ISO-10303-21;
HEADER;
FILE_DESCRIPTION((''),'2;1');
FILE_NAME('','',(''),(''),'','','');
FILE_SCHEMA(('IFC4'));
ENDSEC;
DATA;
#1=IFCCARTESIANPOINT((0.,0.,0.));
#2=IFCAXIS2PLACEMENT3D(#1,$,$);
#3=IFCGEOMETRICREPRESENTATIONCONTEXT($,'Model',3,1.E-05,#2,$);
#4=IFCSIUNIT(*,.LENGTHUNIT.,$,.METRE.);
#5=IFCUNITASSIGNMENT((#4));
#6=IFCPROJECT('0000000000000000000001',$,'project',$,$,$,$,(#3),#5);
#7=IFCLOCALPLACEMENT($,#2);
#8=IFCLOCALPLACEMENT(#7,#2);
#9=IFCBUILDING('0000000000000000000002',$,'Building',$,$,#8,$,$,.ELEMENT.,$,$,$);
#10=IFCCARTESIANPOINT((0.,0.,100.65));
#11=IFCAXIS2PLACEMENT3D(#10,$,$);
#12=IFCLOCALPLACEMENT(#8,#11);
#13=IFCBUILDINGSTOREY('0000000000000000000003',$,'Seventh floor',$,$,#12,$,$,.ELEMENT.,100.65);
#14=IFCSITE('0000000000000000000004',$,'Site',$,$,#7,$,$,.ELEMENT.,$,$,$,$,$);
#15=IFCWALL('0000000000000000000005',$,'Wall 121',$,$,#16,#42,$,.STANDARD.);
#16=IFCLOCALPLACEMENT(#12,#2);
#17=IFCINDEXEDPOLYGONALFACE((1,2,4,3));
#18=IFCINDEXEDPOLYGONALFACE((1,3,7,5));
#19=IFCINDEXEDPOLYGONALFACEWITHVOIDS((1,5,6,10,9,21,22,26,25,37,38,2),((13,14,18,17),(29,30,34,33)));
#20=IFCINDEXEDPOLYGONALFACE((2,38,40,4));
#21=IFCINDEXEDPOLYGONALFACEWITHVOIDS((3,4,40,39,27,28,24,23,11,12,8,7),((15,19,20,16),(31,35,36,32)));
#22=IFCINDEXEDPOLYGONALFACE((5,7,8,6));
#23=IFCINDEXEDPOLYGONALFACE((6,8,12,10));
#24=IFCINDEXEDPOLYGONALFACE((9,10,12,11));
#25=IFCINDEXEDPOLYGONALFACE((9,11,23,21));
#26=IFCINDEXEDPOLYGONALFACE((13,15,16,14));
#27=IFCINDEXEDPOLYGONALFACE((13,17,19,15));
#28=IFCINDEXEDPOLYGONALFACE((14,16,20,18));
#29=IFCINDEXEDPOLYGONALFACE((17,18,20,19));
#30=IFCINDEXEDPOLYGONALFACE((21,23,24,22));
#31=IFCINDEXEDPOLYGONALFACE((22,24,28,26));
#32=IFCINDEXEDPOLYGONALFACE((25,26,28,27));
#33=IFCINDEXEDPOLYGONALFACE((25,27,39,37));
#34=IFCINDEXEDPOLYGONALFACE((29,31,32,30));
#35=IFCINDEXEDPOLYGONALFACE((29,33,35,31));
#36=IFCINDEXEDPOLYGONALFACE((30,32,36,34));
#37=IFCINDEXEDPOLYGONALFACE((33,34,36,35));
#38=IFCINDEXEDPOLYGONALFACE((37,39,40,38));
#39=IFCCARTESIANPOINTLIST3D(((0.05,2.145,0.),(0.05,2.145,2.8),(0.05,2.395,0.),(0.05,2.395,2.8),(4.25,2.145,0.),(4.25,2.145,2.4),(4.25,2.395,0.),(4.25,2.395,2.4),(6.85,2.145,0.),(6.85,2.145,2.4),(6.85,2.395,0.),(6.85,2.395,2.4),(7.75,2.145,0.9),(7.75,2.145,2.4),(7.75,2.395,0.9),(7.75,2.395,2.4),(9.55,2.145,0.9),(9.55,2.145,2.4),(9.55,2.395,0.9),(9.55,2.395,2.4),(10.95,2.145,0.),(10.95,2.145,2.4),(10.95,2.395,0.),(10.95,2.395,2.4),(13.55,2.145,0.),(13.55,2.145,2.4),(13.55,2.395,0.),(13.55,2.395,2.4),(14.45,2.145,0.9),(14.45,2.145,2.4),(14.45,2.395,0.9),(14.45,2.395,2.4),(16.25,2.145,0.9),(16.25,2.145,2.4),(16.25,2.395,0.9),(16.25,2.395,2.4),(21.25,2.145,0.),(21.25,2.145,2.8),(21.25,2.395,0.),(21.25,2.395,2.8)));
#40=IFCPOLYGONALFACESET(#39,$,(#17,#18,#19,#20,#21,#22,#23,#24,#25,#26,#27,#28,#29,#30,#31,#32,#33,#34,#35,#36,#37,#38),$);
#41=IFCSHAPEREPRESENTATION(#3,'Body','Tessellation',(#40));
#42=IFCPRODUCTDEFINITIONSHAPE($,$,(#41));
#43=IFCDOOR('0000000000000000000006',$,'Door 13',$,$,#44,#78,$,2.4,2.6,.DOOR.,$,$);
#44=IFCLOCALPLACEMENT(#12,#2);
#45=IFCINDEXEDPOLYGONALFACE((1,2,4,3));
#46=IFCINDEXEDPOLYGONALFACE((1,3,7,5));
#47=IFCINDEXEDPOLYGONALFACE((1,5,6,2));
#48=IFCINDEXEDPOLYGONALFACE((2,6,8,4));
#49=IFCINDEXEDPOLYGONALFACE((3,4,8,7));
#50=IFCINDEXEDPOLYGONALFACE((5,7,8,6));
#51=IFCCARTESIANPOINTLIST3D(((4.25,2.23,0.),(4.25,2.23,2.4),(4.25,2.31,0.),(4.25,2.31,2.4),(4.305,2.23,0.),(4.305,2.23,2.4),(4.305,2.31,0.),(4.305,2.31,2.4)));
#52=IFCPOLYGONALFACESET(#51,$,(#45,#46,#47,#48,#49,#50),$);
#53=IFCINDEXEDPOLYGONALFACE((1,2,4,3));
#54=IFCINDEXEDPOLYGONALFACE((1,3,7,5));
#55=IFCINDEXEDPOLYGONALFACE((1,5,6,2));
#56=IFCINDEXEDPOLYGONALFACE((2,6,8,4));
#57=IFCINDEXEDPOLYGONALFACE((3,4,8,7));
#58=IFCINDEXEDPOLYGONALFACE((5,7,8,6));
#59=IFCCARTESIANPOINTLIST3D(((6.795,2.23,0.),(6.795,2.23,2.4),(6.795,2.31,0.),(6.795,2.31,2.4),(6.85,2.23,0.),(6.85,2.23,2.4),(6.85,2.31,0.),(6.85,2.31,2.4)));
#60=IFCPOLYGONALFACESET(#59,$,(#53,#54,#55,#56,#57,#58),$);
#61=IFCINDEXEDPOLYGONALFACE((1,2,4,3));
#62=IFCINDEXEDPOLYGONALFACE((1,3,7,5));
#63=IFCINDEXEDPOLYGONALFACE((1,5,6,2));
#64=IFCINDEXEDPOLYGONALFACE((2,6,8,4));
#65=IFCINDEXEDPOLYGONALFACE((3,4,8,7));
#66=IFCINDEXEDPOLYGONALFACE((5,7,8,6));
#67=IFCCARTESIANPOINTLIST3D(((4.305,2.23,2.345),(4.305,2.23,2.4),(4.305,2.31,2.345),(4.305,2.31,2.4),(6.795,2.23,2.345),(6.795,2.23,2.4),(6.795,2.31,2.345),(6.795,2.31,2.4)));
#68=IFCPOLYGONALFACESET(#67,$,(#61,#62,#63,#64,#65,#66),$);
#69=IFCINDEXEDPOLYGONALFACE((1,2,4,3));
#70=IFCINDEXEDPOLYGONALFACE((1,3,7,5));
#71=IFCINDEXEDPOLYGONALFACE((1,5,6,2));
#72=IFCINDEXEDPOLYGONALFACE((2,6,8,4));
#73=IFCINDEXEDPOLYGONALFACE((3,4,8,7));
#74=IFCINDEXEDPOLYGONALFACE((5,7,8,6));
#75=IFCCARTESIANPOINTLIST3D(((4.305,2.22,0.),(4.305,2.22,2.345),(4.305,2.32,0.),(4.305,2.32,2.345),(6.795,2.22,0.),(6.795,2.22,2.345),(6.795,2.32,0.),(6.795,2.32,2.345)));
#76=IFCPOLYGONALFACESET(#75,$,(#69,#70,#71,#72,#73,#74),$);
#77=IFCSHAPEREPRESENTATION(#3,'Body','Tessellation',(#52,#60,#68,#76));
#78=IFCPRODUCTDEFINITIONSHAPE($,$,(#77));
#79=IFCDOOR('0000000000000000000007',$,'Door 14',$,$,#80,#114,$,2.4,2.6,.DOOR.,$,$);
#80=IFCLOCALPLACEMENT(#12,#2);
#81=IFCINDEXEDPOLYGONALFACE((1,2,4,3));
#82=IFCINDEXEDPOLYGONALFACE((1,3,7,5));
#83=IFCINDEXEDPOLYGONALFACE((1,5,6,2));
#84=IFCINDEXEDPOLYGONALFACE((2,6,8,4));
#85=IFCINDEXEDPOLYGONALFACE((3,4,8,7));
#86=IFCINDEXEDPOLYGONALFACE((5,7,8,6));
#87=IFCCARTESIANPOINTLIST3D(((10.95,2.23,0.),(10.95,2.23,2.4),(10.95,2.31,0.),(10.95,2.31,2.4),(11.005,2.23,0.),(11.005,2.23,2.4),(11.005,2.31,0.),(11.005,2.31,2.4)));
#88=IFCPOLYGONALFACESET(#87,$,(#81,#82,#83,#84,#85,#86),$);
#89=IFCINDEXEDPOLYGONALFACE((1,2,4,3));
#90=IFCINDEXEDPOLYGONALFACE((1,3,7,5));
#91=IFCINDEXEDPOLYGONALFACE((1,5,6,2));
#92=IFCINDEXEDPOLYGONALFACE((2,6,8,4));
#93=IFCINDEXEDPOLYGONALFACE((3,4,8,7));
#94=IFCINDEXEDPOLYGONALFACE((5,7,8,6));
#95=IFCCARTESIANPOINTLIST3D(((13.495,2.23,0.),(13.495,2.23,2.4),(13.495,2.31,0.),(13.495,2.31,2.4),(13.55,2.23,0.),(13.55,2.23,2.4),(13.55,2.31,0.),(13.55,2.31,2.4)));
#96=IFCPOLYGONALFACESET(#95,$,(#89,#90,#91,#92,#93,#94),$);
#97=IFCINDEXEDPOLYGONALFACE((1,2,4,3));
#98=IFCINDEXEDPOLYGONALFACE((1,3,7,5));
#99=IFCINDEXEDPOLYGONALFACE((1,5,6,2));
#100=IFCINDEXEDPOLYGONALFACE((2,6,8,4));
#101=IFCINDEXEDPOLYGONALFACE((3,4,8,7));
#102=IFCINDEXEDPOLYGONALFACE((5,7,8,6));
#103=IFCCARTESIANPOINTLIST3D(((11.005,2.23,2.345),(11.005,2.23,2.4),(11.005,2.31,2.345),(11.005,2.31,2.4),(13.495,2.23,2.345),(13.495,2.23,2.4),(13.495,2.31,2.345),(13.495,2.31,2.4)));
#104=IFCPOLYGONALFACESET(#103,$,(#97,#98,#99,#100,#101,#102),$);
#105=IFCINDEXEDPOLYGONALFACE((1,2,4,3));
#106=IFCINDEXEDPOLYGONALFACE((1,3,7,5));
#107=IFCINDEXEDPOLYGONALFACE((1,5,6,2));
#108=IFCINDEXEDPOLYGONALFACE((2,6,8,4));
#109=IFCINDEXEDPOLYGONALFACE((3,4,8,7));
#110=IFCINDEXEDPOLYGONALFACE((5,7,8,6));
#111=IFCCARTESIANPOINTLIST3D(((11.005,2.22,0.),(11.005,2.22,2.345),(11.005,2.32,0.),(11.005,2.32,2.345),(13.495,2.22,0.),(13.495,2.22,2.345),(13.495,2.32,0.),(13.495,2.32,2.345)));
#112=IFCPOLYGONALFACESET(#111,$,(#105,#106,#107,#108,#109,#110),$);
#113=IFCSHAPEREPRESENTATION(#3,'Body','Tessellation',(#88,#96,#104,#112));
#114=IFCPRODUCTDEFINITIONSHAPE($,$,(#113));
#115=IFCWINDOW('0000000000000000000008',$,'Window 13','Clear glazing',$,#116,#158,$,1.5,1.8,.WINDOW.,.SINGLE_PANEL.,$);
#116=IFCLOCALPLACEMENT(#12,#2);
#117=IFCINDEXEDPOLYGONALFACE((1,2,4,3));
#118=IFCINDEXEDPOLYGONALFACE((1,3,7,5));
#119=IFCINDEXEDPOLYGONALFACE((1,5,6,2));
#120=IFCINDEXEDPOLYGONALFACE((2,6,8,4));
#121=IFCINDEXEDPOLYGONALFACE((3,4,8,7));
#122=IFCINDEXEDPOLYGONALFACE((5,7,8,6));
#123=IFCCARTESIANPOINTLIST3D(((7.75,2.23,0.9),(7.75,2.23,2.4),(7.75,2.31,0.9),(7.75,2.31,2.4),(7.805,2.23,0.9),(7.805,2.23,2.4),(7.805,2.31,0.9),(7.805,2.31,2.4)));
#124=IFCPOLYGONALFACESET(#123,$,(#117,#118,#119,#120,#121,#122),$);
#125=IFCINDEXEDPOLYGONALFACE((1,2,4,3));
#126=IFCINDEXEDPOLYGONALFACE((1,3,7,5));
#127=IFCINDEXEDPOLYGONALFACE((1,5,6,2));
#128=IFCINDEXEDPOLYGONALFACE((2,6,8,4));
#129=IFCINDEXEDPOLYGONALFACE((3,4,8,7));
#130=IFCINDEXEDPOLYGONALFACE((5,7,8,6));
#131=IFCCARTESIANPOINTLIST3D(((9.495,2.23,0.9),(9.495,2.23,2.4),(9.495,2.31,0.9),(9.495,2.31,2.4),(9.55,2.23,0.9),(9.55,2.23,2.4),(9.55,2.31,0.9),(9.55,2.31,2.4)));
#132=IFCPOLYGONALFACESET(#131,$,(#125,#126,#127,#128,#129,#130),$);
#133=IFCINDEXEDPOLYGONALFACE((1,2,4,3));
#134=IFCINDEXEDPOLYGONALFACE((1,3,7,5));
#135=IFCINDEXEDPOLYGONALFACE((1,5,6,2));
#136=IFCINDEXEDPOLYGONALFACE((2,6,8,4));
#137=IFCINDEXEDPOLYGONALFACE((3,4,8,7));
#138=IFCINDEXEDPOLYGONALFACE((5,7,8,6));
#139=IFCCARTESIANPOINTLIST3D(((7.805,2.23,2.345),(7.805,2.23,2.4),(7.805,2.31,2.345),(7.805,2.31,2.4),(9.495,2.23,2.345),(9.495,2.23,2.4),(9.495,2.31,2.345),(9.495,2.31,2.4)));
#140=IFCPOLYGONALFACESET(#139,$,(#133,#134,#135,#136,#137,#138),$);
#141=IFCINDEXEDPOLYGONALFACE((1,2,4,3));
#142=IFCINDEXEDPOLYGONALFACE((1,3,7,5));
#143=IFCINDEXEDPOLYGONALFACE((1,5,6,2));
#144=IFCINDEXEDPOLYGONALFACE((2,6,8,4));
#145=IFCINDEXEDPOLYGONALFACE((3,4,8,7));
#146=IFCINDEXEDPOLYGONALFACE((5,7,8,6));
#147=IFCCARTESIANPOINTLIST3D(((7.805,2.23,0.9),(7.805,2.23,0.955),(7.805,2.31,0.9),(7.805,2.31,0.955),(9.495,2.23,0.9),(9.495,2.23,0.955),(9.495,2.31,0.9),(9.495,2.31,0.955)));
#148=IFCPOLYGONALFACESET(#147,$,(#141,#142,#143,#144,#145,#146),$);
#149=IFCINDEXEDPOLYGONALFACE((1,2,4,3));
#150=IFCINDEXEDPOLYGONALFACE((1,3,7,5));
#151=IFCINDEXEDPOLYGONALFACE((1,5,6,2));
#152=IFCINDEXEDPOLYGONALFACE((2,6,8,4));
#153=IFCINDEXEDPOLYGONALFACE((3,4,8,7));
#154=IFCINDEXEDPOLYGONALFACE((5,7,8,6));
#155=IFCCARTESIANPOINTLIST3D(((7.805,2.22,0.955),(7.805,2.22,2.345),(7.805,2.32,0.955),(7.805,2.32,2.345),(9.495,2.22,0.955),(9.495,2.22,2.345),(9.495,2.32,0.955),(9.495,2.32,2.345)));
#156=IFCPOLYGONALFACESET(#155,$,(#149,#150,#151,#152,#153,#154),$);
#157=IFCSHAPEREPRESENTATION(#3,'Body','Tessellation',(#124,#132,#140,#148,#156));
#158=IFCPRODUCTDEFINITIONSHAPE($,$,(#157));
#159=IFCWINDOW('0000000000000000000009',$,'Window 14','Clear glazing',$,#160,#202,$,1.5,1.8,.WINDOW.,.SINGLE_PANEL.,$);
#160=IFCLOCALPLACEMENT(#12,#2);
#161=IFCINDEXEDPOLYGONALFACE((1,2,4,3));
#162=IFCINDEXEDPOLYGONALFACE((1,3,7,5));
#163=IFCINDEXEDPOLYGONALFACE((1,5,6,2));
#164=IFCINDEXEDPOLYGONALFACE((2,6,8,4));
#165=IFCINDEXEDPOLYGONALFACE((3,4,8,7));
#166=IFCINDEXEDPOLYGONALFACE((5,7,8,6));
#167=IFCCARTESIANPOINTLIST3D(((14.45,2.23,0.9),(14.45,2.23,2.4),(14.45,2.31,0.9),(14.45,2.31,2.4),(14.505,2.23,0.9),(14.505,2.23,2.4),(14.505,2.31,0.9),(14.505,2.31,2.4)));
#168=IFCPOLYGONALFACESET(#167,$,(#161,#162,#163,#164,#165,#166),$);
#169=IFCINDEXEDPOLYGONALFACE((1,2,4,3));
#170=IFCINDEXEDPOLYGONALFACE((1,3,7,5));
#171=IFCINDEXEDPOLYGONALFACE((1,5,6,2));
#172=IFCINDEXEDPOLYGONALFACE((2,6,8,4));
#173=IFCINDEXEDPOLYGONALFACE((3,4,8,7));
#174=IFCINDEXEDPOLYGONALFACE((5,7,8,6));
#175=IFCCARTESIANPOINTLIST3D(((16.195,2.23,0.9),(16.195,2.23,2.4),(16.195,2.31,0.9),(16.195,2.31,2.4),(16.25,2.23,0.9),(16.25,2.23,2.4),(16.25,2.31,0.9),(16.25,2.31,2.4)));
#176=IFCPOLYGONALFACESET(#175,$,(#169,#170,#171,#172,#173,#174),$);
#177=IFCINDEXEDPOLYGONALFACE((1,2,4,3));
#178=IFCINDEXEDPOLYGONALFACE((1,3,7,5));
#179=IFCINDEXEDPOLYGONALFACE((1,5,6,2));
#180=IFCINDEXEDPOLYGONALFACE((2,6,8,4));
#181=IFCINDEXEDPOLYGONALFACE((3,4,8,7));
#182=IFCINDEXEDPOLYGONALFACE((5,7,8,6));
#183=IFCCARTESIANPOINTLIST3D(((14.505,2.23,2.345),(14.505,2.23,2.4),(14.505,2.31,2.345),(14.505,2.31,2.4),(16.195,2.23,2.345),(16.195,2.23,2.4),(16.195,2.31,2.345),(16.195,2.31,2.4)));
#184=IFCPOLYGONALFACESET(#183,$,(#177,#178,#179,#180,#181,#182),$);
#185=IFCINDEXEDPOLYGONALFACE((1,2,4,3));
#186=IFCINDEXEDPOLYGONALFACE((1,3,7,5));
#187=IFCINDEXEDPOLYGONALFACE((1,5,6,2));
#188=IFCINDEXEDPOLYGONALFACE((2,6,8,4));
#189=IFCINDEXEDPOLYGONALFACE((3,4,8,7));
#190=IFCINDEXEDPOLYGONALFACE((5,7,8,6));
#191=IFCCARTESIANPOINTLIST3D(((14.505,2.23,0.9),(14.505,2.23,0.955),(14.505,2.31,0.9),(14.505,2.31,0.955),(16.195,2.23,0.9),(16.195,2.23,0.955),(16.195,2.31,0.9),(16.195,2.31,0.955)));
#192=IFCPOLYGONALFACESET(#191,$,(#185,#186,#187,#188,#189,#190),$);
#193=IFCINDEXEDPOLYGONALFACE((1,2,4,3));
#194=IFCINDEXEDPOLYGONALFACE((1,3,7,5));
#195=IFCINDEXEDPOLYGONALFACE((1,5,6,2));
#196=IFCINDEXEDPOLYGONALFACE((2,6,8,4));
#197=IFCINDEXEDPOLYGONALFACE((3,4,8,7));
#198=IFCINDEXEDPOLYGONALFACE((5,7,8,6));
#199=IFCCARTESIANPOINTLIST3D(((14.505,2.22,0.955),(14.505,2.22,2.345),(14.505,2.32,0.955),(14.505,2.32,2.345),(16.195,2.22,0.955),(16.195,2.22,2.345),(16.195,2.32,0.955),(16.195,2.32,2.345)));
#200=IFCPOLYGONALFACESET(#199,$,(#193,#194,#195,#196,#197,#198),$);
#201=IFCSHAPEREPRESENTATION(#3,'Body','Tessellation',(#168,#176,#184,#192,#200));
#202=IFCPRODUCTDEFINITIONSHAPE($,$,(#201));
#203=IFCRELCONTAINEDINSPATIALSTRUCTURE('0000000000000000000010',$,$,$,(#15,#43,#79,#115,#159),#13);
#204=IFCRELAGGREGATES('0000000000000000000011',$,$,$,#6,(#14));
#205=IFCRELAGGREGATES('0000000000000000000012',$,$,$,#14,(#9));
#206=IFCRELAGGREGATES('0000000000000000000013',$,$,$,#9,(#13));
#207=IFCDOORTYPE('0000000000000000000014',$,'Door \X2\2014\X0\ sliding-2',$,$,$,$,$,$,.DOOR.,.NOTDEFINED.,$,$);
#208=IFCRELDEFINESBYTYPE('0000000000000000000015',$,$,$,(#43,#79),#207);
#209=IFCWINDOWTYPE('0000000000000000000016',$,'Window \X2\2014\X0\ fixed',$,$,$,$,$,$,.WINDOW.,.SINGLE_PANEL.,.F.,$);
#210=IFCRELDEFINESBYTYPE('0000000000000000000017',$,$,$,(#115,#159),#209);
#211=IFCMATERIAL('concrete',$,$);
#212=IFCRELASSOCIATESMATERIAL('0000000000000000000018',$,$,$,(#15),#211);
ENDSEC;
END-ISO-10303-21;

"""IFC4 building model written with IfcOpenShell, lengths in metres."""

from ifc_helpers import new_model, si_unit, frame, frame_2d, origin, place, context, project, spatial, rectangle, extrude, material, type_object, element, fill, save


model = new_model("IFC4")

# Units and contexts
model_context = context("Model", 3, precision=1e-05, world=origin())
ifc_project = project(units=[si_unit("LENGTHUNIT", "METRE")], contexts=[model_context])

# Site, building, storey
site_placement = place(None, origin())
site = spatial("IfcSite", under=ifc_project, at=site_placement, Name="Site", CompositionType="ELEMENT")
building_placement = place(site_placement, origin())
building = spatial("IfcBuilding", under=site, at=building_placement, Name="Building", CompositionType="ELEMENT")
storey_placement = place(building_placement, frame((0.0, 0.0, 100.65)))
storey = spatial("IfcBuildingStorey", under=building, at=storey_placement, Name="Seventh floor", CompositionType="ELEMENT", Elevation=100.65)

# Shared definitions
ifc_material = material(Name="concrete")

# Wall, openings, doors, windows
wall_1_placement = place(storey_placement, frame((0.05, 2.27, 0.0), z_axis=(0.0, 0.0, 1.0), x_axis=(1.0, 0.0, 0.0)))
wall_1 = element("IfcWall", 1, at=wall_1_placement, inside=storey, material=ifc_material, Name="Wall 121", PredefinedType="STANDARD", context=model_context, shape_type="SweptSolid", body=[
    extrude(rectangle(XDim=21.2, YDim=0.25, at=frame_2d((10.6, 0.0))), origin(), (0.0, 0.0, 1.0), 2.8),
])
opening_1_placement = place(storey_placement, frame((4.25, 2.27, 0.0), z_axis=(0.0, 0.0, 1.0), x_axis=(1.0, 0.0, 0.0)))
opening_1 = element("IfcOpeningElement", 2, at=opening_1_placement, cuts=wall_1, PredefinedType="OPENING", context=model_context, shape_type="SweptSolid", body=[
    extrude(rectangle(XDim=2.6, YDim=0.31, at=frame_2d((1.3, 0.0))), origin(), (0.0, 0.0, 1.0), 2.4),
])
opening_2_placement = place(storey_placement, frame((7.75, 2.27, 0.9), z_axis=(0.0, 0.0, 1.0), x_axis=(1.0, 0.0, 0.0)))
opening_2 = element("IfcOpeningElement", 3, at=opening_2_placement, cuts=wall_1, PredefinedType="OPENING", context=model_context, shape_type="SweptSolid", body=[
    extrude(rectangle(XDim=1.8, YDim=0.31, at=frame_2d((0.9, 0.0))), origin(), (0.0, 0.0, 1.0), 1.5),
])
opening_3_placement = place(storey_placement, frame((10.95, 2.27, 0.0), z_axis=(0.0, 0.0, 1.0), x_axis=(1.0, 0.0, 0.0)))
opening_3 = element("IfcOpeningElement", 4, at=opening_3_placement, cuts=wall_1, PredefinedType="OPENING", context=model_context, shape_type="SweptSolid", body=[
    extrude(rectangle(XDim=2.6, YDim=0.31, at=frame_2d((1.3, 0.0))), origin(), (0.0, 0.0, 1.0), 2.4),
])
opening_4_placement = place(storey_placement, frame((14.45, 2.27, 0.9), z_axis=(0.0, 0.0, 1.0), x_axis=(1.0, 0.0, 0.0)))
opening_4 = element("IfcOpeningElement", 5, at=opening_4_placement, cuts=wall_1, PredefinedType="OPENING", context=model_context, shape_type="SweptSolid", body=[
    extrude(rectangle(XDim=1.8, YDim=0.31, at=frame_2d((0.9, 0.0))), origin(), (0.0, 0.0, 1.0), 1.5),
])
door_type = type_object("IfcDoorType", Name="Door — sliding-2", PredefinedType="DOOR")
door_1_placement = place(storey_placement, frame((4.25, 2.27, 0.0), z_axis=(0.0, 0.0, 1.0), x_axis=(1.0, 0.0, 0.0)))
door_1 = element("IfcDoor", 6, at=door_1_placement, inside=storey, type_object=door_type, Name="Door 13", OverallHeight=2.4, OverallWidth=2.6, PredefinedType="DOOR", context=model_context, shape_type="SweptSolid", body=[
    extrude(rectangle(XDim=0.055, YDim=0.08, at=frame_2d((0.0275, 0.0))), origin(), (0.0, 0.0, 1.0), 2.4),
    extrude(rectangle(XDim=0.055, YDim=0.08, at=frame_2d((2.5725, 0.0))), origin(), (0.0, 0.0, 1.0), 2.4),
    extrude(rectangle(XDim=2.49, YDim=0.08, at=frame_2d((1.3, 0.0))), frame((0.0, 0.0, 2.345)), (0.0, 0.0, 1.0), 0.055),
    extrude(rectangle(XDim=2.49, YDim=0.1, at=frame_2d((1.3, 0.0))), origin(), (0.0, 0.0, 1.0), 2.345),
])
fill(opening_1, door_1)
door_2_placement = place(storey_placement, frame((10.95, 2.27, 0.0), z_axis=(0.0, 0.0, 1.0), x_axis=(1.0, 0.0, 0.0)))
door_2 = element("IfcDoor", 7, at=door_2_placement, inside=storey, type_object=door_type, Name="Door 14", OverallHeight=2.4, OverallWidth=2.6, PredefinedType="DOOR", context=model_context, shape_type="SweptSolid", body=[
    extrude(rectangle(XDim=0.055, YDim=0.08, at=frame_2d((0.0275, 0.0))), origin(), (0.0, 0.0, 1.0), 2.4),
    extrude(rectangle(XDim=0.055, YDim=0.08, at=frame_2d((2.5725, 0.0))), origin(), (0.0, 0.0, 1.0), 2.4),
    extrude(rectangle(XDim=2.49, YDim=0.08, at=frame_2d((1.3, 0.0))), frame((0.0, 0.0, 2.345)), (0.0, 0.0, 1.0), 0.055),
    extrude(rectangle(XDim=2.49, YDim=0.1, at=frame_2d((1.3, 0.0))), origin(), (0.0, 0.0, 1.0), 2.345),
])
fill(opening_3, door_2)
window_type = type_object("IfcWindowType", Name="Window — fixed", ParameterTakesPrecedence=False, PartitioningType="SINGLE_PANEL", PredefinedType="WINDOW")
window_1_placement = place(storey_placement, frame((7.75, 2.27, 0.9), z_axis=(0.0, 0.0, 1.0), x_axis=(1.0, 0.0, 0.0)))
window_1 = element("IfcWindow", 8, at=window_1_placement, inside=storey, type_object=window_type, Name="Window 13", Description="Clear glazing", OverallHeight=1.5, OverallWidth=1.8, PartitioningType="SINGLE_PANEL", PredefinedType="WINDOW", context=model_context, shape_type="SweptSolid", body=[
    extrude(rectangle(XDim=0.055, YDim=0.08, at=frame_2d((0.0275, 0.0))), origin(), (0.0, 0.0, 1.0), 1.5),
    extrude(rectangle(XDim=0.055, YDim=0.08, at=frame_2d((1.7725, 0.0))), origin(), (0.0, 0.0, 1.0), 1.5),
    extrude(rectangle(XDim=1.69, YDim=0.08, at=frame_2d((0.9, 0.0))), frame((0.0, 0.0, 1.445)), (0.0, 0.0, 1.0), 0.055),
    extrude(rectangle(XDim=1.69, YDim=0.08, at=frame_2d((0.9, 0.0))), origin(), (0.0, 0.0, 1.0), 0.055),
    extrude(rectangle(XDim=1.69, YDim=0.1, at=frame_2d((0.9, 0.0))), frame((0.0, 0.0, 0.055)), (0.0, 0.0, 1.0), 1.39),
])
fill(opening_2, window_1)
window_2_placement = place(storey_placement, frame((14.45, 2.27, 0.9), z_axis=(0.0, 0.0, 1.0), x_axis=(1.0, 0.0, 0.0)))
window_2 = element("IfcWindow", 9, at=window_2_placement, inside=storey, type_object=window_type, Name="Window 14", Description="Clear glazing", OverallHeight=1.5, OverallWidth=1.8, PartitioningType="SINGLE_PANEL", PredefinedType="WINDOW", context=model_context, shape_type="SweptSolid", body=[
    extrude(rectangle(XDim=0.055, YDim=0.08, at=frame_2d((0.0275, 0.0))), origin(), (0.0, 0.0, 1.0), 1.5),
    extrude(rectangle(XDim=0.055, YDim=0.08, at=frame_2d((1.7725, 0.0))), origin(), (0.0, 0.0, 1.0), 1.5),
    extrude(rectangle(XDim=1.69, YDim=0.08, at=frame_2d((0.9, 0.0))), frame((0.0, 0.0, 1.445)), (0.0, 0.0, 1.0), 0.055),
    extrude(rectangle(XDim=1.69, YDim=0.08, at=frame_2d((0.9, 0.0))), origin(), (0.0, 0.0, 1.0), 0.055),
    extrude(rectangle(XDim=1.69, YDim=0.1, at=frame_2d((0.9, 0.0))), frame((0.0, 0.0, 0.055)), (0.0, 0.0, 1.0), 1.39),
])
fill(opening_4, window_2)

save(model, "model.ifc")
